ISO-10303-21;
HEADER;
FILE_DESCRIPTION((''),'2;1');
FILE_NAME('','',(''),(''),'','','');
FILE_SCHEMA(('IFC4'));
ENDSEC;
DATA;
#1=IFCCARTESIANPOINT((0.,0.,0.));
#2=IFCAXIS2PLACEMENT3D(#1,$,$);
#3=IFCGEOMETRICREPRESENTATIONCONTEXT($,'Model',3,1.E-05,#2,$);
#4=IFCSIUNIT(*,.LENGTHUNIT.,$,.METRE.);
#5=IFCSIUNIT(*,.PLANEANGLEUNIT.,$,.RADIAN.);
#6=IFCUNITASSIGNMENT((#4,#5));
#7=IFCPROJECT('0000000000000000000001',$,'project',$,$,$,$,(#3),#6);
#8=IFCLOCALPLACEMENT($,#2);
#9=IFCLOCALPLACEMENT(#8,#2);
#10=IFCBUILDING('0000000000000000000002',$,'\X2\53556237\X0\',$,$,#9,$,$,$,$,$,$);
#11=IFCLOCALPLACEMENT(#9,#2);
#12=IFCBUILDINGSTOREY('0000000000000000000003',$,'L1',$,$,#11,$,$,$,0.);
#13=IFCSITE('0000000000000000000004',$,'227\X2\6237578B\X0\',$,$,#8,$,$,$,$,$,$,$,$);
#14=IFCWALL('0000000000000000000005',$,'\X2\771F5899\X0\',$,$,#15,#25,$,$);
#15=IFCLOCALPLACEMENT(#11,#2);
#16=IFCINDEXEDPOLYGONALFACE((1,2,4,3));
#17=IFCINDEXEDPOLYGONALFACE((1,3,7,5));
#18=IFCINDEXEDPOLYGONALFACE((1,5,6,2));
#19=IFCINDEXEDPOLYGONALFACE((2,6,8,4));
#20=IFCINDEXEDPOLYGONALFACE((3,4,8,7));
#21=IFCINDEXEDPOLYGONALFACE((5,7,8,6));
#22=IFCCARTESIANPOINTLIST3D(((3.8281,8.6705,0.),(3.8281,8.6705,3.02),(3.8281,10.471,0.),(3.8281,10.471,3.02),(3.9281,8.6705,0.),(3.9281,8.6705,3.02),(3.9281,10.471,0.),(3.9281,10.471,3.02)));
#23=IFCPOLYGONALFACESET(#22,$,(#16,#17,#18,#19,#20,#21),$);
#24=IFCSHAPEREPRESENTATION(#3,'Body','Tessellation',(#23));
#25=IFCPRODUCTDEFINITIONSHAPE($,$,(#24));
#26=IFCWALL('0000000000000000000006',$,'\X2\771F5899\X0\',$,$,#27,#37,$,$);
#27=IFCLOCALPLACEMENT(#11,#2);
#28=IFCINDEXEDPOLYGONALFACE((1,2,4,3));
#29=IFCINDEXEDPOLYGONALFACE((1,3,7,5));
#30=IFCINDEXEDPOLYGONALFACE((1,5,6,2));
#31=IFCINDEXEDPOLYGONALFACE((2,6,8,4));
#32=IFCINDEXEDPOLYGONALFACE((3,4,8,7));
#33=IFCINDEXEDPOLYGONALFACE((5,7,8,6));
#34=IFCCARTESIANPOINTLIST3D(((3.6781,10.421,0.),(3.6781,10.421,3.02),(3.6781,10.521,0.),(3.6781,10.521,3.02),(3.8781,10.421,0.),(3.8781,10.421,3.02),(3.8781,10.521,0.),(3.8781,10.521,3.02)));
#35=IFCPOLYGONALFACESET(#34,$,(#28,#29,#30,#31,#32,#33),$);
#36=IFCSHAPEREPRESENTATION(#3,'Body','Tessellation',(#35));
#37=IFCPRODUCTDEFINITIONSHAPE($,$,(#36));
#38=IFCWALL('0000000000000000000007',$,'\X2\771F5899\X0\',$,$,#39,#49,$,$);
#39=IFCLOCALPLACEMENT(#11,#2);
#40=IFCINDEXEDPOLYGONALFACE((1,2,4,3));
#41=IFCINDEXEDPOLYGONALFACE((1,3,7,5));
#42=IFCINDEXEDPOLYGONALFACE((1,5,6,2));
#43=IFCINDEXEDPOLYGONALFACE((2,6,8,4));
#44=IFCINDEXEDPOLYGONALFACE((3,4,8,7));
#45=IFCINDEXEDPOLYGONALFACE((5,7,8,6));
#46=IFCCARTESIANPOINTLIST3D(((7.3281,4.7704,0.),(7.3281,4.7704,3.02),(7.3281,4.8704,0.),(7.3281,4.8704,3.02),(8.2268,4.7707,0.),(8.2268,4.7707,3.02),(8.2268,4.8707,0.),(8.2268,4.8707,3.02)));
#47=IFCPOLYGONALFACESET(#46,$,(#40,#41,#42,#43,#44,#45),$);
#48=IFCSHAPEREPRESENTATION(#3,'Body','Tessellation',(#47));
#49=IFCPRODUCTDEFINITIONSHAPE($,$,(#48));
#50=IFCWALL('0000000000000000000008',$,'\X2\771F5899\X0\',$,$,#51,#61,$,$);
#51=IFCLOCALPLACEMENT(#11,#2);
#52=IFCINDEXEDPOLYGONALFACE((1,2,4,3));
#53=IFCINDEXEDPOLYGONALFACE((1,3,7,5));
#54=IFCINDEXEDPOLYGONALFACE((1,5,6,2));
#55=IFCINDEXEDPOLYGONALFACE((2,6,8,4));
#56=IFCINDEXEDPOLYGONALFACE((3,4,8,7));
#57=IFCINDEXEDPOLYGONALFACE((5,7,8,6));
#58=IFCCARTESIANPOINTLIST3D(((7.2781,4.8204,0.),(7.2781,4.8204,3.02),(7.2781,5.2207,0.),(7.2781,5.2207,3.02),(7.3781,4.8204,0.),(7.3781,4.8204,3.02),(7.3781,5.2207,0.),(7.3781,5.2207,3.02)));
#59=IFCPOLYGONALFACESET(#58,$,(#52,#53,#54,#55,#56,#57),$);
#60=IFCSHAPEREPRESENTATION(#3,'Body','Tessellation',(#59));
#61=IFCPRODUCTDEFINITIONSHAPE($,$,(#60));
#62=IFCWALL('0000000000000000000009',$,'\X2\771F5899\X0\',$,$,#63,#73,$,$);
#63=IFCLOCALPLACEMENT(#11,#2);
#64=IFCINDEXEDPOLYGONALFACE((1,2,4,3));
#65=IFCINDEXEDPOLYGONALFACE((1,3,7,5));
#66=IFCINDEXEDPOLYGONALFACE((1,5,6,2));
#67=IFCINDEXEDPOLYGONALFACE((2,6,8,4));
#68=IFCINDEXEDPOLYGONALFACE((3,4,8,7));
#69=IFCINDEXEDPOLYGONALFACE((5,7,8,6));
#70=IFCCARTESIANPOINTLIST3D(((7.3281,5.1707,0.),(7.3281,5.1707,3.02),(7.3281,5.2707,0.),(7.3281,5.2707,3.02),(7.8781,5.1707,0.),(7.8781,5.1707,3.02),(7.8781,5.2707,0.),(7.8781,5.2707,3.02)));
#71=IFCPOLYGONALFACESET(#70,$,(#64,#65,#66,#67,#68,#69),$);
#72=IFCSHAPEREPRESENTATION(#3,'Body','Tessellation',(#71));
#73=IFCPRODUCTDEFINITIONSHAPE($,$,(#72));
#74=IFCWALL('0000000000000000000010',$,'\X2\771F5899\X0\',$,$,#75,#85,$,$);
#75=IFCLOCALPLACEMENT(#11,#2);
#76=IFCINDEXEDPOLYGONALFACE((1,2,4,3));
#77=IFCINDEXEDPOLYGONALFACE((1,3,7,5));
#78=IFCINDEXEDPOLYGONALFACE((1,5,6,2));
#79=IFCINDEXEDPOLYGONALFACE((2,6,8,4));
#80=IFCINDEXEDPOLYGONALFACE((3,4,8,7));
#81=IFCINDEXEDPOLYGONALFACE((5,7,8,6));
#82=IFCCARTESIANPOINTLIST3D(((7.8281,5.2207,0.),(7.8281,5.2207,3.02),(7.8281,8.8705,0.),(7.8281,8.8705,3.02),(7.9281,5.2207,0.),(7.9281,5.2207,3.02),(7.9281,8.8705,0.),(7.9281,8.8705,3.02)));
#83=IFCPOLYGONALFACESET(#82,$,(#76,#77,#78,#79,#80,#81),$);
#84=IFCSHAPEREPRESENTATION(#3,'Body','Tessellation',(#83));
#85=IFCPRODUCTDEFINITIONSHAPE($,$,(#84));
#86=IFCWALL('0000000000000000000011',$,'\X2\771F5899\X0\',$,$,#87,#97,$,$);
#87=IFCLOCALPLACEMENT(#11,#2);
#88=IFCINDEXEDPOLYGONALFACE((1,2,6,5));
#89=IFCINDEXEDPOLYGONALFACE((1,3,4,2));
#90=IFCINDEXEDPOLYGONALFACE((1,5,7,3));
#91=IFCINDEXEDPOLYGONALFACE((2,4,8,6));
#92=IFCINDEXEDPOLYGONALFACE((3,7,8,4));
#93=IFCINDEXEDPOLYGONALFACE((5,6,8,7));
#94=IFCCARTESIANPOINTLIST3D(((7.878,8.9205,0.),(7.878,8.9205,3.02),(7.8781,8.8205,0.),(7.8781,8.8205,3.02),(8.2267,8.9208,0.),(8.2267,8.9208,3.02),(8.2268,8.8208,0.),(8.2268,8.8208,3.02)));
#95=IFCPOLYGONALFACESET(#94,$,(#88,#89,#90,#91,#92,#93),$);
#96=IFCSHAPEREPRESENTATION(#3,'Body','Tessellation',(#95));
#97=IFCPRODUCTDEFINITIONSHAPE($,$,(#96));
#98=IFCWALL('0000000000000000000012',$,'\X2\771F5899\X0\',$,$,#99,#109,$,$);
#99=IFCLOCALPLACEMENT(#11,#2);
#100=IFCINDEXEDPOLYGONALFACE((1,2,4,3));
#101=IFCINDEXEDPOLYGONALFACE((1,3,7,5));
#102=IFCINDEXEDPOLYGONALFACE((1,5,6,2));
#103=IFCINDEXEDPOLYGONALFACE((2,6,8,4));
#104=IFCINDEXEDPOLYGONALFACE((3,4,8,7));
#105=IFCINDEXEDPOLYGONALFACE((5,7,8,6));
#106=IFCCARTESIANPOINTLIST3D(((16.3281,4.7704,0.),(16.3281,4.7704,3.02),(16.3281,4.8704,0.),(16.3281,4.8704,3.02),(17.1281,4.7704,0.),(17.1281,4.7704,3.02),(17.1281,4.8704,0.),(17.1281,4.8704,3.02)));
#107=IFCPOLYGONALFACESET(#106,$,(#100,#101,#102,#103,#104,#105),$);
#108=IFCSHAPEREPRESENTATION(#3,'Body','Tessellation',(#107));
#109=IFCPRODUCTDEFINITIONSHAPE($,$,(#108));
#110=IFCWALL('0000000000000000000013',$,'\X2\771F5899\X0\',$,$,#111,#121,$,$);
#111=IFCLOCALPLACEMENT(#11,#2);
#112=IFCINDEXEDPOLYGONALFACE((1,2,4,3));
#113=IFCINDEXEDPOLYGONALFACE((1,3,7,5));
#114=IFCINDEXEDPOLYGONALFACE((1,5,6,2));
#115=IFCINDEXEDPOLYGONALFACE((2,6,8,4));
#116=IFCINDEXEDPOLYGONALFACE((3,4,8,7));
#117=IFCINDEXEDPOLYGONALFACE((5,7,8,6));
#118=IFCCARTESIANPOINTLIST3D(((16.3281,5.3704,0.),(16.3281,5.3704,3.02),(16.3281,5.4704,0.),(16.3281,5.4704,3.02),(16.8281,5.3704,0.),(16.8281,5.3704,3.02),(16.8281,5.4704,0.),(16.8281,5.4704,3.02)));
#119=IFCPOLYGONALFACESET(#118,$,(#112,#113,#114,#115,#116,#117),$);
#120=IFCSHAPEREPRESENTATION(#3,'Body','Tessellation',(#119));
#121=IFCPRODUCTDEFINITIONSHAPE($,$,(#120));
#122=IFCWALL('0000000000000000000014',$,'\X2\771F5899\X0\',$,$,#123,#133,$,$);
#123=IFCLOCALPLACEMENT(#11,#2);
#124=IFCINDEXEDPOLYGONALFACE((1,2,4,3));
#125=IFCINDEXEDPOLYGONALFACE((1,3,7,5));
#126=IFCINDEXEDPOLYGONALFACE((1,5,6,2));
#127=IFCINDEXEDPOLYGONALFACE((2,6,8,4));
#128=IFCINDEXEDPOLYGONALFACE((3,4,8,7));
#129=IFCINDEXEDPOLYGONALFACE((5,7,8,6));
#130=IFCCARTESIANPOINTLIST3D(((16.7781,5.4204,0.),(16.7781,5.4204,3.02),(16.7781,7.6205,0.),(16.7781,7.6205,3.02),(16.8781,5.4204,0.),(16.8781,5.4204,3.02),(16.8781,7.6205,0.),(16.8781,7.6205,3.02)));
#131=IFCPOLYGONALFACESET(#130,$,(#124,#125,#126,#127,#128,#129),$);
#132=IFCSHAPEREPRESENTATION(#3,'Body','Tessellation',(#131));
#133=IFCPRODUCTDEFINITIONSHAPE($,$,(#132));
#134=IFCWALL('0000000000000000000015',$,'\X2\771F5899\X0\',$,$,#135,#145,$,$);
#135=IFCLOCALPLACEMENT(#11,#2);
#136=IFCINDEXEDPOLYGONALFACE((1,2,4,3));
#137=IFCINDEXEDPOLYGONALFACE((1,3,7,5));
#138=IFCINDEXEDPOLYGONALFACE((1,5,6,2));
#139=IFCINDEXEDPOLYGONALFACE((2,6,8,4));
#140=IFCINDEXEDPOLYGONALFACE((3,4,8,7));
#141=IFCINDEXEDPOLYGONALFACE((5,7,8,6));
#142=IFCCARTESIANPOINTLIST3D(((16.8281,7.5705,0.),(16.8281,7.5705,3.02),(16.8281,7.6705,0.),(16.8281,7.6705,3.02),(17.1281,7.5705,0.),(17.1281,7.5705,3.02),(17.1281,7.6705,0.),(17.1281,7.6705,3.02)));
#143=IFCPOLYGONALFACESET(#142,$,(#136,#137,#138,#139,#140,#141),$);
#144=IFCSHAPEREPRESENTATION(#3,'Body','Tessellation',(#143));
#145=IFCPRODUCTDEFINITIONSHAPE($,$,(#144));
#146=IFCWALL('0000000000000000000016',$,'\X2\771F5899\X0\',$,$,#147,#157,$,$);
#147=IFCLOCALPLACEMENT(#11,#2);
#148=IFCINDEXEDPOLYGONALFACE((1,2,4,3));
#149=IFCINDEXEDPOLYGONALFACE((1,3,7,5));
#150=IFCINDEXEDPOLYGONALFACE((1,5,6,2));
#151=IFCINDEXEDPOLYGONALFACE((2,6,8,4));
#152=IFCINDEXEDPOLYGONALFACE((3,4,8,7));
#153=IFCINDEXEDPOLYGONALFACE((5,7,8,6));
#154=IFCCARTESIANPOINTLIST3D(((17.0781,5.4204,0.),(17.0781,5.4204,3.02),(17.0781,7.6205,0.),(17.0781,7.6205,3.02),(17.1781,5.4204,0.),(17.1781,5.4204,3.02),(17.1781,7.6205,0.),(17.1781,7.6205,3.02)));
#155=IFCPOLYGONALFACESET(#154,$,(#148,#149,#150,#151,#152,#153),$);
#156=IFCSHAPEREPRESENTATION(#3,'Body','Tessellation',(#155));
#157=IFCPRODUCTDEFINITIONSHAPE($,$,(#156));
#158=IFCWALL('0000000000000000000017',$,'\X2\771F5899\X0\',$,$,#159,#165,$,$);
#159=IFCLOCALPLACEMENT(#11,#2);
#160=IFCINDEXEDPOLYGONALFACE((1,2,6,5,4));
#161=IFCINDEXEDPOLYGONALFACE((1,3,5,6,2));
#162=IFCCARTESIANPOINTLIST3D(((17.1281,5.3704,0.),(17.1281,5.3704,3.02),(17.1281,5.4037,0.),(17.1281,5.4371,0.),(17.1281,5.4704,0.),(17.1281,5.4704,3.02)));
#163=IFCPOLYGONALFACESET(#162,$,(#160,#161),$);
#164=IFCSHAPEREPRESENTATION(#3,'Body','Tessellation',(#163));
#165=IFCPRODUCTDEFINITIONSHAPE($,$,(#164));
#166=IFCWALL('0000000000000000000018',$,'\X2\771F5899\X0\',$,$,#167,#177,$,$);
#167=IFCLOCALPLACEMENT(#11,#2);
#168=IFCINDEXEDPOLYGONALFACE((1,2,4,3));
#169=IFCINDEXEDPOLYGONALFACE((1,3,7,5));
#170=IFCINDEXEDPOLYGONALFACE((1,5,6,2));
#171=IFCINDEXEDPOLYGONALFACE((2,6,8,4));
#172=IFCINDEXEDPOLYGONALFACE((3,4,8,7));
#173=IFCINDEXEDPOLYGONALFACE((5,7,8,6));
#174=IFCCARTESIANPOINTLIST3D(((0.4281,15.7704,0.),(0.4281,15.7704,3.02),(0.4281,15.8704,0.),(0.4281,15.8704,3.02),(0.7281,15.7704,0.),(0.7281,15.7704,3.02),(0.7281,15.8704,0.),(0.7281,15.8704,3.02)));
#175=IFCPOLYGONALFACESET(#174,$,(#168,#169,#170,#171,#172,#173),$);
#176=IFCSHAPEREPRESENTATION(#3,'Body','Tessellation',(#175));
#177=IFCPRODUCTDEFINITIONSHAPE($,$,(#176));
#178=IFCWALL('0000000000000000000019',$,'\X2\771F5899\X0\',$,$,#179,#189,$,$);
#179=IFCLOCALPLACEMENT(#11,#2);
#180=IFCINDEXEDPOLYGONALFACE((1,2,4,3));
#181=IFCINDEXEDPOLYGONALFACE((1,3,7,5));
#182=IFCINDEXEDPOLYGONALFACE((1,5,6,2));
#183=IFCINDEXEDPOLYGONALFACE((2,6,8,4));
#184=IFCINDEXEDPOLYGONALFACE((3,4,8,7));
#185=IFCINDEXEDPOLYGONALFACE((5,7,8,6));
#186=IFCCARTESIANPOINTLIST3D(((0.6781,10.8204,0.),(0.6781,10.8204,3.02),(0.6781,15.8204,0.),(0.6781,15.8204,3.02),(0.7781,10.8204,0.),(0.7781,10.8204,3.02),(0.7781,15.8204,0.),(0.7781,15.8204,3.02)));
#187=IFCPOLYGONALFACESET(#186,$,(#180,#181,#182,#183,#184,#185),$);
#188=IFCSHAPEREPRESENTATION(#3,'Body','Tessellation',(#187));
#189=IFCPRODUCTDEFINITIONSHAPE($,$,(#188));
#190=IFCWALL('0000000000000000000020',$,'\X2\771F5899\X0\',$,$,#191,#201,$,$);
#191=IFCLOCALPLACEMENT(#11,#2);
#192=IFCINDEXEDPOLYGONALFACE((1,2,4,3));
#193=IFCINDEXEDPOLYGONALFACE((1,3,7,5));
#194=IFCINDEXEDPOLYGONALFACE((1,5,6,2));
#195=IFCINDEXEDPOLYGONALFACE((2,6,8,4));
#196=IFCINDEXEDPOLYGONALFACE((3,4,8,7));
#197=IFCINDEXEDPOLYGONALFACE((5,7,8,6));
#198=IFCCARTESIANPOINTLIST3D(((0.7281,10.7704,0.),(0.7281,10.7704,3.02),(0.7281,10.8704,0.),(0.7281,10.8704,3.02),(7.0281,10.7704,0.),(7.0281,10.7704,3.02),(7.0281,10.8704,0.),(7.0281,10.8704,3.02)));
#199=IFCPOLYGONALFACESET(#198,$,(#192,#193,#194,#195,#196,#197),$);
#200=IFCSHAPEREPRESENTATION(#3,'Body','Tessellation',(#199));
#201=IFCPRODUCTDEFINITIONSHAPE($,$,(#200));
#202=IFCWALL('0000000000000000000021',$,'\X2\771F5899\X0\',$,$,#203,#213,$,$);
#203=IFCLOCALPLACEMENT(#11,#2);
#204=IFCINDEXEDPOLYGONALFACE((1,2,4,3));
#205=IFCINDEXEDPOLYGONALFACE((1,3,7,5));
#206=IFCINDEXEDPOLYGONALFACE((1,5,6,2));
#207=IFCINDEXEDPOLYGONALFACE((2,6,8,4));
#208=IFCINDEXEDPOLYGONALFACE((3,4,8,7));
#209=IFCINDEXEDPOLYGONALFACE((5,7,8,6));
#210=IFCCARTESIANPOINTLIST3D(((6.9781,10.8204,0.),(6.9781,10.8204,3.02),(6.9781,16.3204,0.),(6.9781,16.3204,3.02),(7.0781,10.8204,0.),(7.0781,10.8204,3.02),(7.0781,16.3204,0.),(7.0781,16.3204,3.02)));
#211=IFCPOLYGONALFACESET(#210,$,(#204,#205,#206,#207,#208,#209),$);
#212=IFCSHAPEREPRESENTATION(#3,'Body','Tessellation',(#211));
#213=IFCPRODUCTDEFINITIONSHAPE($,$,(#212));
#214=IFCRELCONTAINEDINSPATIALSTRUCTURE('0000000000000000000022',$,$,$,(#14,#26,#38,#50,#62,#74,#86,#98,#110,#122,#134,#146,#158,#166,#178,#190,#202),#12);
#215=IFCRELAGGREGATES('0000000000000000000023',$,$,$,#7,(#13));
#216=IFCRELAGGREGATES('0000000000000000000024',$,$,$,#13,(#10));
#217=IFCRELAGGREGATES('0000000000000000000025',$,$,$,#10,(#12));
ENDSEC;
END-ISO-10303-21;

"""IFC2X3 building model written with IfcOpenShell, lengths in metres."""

from ifc_helpers import new_model, si_unit, origin, place, context, project, spatial, polyline, outline, extrude, element, save


model = new_model("IFC2X3")

# Units and contexts
model_context = context("Model", 3, precision=1e-05, world=origin())
ifc_project = project(units=[si_unit("LENGTHUNIT", "METRE"), si_unit("PLANEANGLEUNIT", "RADIAN")], contexts=[model_context])

# Site, building, storey
site_placement = place(None, origin())
site = spatial("IfcSite", under=ifc_project, at=site_placement, Name="227户型")
building_placement = place(site_placement, origin())
building = spatial("IfcBuilding", under=site, at=building_placement, Name="单户")
storey_placement = place(building_placement, origin())
storey = spatial("IfcBuildingStorey", under=building, at=storey_placement, Name="L1", Elevation=0.0)

# Walls
wall_1_placement = place(storey_placement, origin())
element("IfcWall", 1, at=wall_1_placement, inside=storey, Name="真墙", context=model_context, shape_type="SweptSolid", body=[
    extrude(outline(polyline([(3.8281, 8.6705), (3.8281, 10.471), (3.9281, 10.471), (3.9281, 8.6705), (3.8281, 8.6705)])), origin(), (0.0, 0.0, 1.0), 3.02),
])
wall_2_placement = place(storey_placement, origin())
element("IfcWall", 2, at=wall_2_placement, inside=storey, Name="真墙", context=model_context, shape_type="SweptSolid", body=[
    extrude(outline(polyline([(3.8781, 10.421), (3.6781, 10.421), (3.6781, 10.521), (3.8781, 10.521), (3.8781, 10.421)])), origin(), (0.0, 0.0, 1.0), 3.02),
])
wall_3_placement = place(storey_placement, origin())
element("IfcWall", 3, at=wall_3_placement, inside=storey, Name="真墙", context=model_context, shape_type="SweptSolid", body=[
    extrude(outline(polyline([(8.2268, 4.7707), (7.3281, 4.7704), (7.3281, 4.8704), (8.2268, 4.8707), (8.2268, 4.7707)])), origin(), (0.0, 0.0, 1.0), 3.02),
])
wall_4_placement = place(storey_placement, origin())
element("IfcWall", 4, at=wall_4_placement, inside=storey, Name="真墙", context=model_context, shape_type="SweptSolid", body=[
    extrude(outline(polyline([(7.2781, 4.8204), (7.2781, 5.2207), (7.3781, 5.2207), (7.3781, 4.8204), (7.2781, 4.8204)])), origin(), (0.0, 0.0, 1.0), 3.02),
])
wall_5_placement = place(storey_placement, origin())
element("IfcWall", 5, at=wall_5_placement, inside=storey, Name="真墙", context=model_context, shape_type="SweptSolid", body=[
    extrude(outline(polyline([(7.3281, 5.2707), (7.8781, 5.2707), (7.8781, 5.1707), (7.3281, 5.1707), (7.3281, 5.2707)])), origin(), (0.0, 0.0, 1.0), 3.02),
])
wall_6_placement = place(storey_placement, origin())
element("IfcWall", 6, at=wall_6_placement, inside=storey, Name="真墙", context=model_context, shape_type="SweptSolid", body=[
    extrude(outline(polyline([(7.8281, 5.2207), (7.8281, 8.8705), (7.9281, 8.8705), (7.9281, 5.2207), (7.8281, 5.2207)])), origin(), (0.0, 0.0, 1.0), 3.02),
])
wall_7_placement = place(storey_placement, origin())
element("IfcWall", 7, at=wall_7_placement, inside=storey, Name="真墙", context=model_context, shape_type="SweptSolid", body=[
    extrude(outline(polyline([(7.878, 8.9205), (8.2267, 8.9208), (8.2268, 8.8208), (7.8781, 8.8205), (7.878, 8.9205)])), origin(), (0.0, 0.0, 1.0), 3.02),
])

# Wall
wall_8_placement = place(storey_placement, origin())
element("IfcWall", 8, at=wall_8_placement, inside=storey, Name="真墙", context=model_context, shape_type="SweptSolid", body=[
    extrude(outline(polyline([(17.1281, 4.7704), (16.3281, 4.7704), (16.3281, 4.8704), (17.1281, 4.8704), (17.1281, 4.7704)])), origin(), (0.0, 0.0, 1.0), 3.02),
])

# Walls
wall_9_placement = place(storey_placement, origin())
element("IfcWall", 9, at=wall_9_placement, inside=storey, Name="真墙", context=model_context, shape_type="SweptSolid", body=[
    extrude(outline(polyline([(16.3281, 5.4704), (16.8281, 5.4704), (16.8281, 5.3704), (16.3281, 5.3704), (16.3281, 5.4704)])), origin(), (0.0, 0.0, 1.0), 3.02),
])
wall_10_placement = place(storey_placement, origin())
element("IfcWall", 10, at=wall_10_placement, inside=storey, Name="真墙", context=model_context, shape_type="SweptSolid", body=[
    extrude(outline(polyline([(16.7781, 5.4204), (16.7781, 7.6205), (16.8781, 7.6205), (16.8781, 5.4204), (16.7781, 5.4204)])), origin(), (0.0, 0.0, 1.0), 3.02),
])
wall_11_placement = place(storey_placement, origin())
element("IfcWall", 11, at=wall_11_placement, inside=storey, Name="真墙", context=model_context, shape_type="SweptSolid", body=[
    extrude(outline(polyline([(16.8281, 7.6705), (17.1281, 7.6705), (17.1281, 7.5705), (16.8281, 7.5705), (16.8281, 7.6705)])), origin(), (0.0, 0.0, 1.0), 3.02),
])
wall_12_placement = place(storey_placement, origin())
element("IfcWall", 12, at=wall_12_placement, inside=storey, Name="真墙", context=model_context, shape_type="SweptSolid", body=[
    extrude(outline(polyline([(17.1781, 7.6205), (17.1781, 5.4204), (17.0781, 5.4204), (17.0781, 7.6205), (17.1781, 7.6205)])), origin(), (0.0, 0.0, 1.0), 3.02),
])
wall_13_placement = place(storey_placement, origin())
element("IfcWall", 13, at=wall_13_placement, inside=storey, Name="真墙", context=model_context, shape_type="SweptSolid", body=[
    extrude(outline(polyline([(17.1281, 5.4704), (17.1281, 5.4704), (17.1281, 5.3704), (17.1281, 5.3704), (17.1281, 5.4704)])), origin(), (0.0, 0.0, 1.0), 3.02),
])
wall_14_placement = place(storey_placement, origin())
element("IfcWall", 14, at=wall_14_placement, inside=storey, Name="真墙", context=model_context, shape_type="SweptSolid", body=[
    extrude(outline(polyline([(0.4281, 15.8704), (0.7281, 15.8704), (0.7281, 15.7704), (0.4281, 15.7704), (0.4281, 15.8704)])), origin(), (0.0, 0.0, 1.0), 3.02),
])
wall_15_placement = place(storey_placement, origin())
element("IfcWall", 15, at=wall_15_placement, inside=storey, Name="真墙", context=model_context, shape_type="SweptSolid", body=[
    extrude(outline(polyline([(0.7781, 15.8204), (0.7781, 10.8204), (0.6781, 10.8204), (0.6781, 15.8204), (0.7781, 15.8204)])), origin(), (0.0, 0.0, 1.0), 3.02),
])
wall_16_placement = place(storey_placement, origin())
element("IfcWall", 16, at=wall_16_placement, inside=storey, Name="真墙", context=model_context, shape_type="SweptSolid", body=[
    extrude(outline(polyline([(0.7281, 10.8704), (7.0281, 10.8704), (7.0281, 10.7704), (0.7281, 10.7704), (0.7281, 10.8704)])), origin(), (0.0, 0.0, 1.0), 3.02),
])
wall_17_placement = place(storey_placement, origin())
element("IfcWall", 17, at=wall_17_placement, inside=storey, Name="真墙", context=model_context, shape_type="SweptSolid", body=[
    extrude(outline(polyline([(6.9781, 10.8204), (6.9781, 16.3204), (7.0781, 16.3204), (7.0781, 10.8204), (6.9781, 10.8204)])), origin(), (0.0, 0.0, 1.0), 3.02),
])

save(model, "model.ifc")
